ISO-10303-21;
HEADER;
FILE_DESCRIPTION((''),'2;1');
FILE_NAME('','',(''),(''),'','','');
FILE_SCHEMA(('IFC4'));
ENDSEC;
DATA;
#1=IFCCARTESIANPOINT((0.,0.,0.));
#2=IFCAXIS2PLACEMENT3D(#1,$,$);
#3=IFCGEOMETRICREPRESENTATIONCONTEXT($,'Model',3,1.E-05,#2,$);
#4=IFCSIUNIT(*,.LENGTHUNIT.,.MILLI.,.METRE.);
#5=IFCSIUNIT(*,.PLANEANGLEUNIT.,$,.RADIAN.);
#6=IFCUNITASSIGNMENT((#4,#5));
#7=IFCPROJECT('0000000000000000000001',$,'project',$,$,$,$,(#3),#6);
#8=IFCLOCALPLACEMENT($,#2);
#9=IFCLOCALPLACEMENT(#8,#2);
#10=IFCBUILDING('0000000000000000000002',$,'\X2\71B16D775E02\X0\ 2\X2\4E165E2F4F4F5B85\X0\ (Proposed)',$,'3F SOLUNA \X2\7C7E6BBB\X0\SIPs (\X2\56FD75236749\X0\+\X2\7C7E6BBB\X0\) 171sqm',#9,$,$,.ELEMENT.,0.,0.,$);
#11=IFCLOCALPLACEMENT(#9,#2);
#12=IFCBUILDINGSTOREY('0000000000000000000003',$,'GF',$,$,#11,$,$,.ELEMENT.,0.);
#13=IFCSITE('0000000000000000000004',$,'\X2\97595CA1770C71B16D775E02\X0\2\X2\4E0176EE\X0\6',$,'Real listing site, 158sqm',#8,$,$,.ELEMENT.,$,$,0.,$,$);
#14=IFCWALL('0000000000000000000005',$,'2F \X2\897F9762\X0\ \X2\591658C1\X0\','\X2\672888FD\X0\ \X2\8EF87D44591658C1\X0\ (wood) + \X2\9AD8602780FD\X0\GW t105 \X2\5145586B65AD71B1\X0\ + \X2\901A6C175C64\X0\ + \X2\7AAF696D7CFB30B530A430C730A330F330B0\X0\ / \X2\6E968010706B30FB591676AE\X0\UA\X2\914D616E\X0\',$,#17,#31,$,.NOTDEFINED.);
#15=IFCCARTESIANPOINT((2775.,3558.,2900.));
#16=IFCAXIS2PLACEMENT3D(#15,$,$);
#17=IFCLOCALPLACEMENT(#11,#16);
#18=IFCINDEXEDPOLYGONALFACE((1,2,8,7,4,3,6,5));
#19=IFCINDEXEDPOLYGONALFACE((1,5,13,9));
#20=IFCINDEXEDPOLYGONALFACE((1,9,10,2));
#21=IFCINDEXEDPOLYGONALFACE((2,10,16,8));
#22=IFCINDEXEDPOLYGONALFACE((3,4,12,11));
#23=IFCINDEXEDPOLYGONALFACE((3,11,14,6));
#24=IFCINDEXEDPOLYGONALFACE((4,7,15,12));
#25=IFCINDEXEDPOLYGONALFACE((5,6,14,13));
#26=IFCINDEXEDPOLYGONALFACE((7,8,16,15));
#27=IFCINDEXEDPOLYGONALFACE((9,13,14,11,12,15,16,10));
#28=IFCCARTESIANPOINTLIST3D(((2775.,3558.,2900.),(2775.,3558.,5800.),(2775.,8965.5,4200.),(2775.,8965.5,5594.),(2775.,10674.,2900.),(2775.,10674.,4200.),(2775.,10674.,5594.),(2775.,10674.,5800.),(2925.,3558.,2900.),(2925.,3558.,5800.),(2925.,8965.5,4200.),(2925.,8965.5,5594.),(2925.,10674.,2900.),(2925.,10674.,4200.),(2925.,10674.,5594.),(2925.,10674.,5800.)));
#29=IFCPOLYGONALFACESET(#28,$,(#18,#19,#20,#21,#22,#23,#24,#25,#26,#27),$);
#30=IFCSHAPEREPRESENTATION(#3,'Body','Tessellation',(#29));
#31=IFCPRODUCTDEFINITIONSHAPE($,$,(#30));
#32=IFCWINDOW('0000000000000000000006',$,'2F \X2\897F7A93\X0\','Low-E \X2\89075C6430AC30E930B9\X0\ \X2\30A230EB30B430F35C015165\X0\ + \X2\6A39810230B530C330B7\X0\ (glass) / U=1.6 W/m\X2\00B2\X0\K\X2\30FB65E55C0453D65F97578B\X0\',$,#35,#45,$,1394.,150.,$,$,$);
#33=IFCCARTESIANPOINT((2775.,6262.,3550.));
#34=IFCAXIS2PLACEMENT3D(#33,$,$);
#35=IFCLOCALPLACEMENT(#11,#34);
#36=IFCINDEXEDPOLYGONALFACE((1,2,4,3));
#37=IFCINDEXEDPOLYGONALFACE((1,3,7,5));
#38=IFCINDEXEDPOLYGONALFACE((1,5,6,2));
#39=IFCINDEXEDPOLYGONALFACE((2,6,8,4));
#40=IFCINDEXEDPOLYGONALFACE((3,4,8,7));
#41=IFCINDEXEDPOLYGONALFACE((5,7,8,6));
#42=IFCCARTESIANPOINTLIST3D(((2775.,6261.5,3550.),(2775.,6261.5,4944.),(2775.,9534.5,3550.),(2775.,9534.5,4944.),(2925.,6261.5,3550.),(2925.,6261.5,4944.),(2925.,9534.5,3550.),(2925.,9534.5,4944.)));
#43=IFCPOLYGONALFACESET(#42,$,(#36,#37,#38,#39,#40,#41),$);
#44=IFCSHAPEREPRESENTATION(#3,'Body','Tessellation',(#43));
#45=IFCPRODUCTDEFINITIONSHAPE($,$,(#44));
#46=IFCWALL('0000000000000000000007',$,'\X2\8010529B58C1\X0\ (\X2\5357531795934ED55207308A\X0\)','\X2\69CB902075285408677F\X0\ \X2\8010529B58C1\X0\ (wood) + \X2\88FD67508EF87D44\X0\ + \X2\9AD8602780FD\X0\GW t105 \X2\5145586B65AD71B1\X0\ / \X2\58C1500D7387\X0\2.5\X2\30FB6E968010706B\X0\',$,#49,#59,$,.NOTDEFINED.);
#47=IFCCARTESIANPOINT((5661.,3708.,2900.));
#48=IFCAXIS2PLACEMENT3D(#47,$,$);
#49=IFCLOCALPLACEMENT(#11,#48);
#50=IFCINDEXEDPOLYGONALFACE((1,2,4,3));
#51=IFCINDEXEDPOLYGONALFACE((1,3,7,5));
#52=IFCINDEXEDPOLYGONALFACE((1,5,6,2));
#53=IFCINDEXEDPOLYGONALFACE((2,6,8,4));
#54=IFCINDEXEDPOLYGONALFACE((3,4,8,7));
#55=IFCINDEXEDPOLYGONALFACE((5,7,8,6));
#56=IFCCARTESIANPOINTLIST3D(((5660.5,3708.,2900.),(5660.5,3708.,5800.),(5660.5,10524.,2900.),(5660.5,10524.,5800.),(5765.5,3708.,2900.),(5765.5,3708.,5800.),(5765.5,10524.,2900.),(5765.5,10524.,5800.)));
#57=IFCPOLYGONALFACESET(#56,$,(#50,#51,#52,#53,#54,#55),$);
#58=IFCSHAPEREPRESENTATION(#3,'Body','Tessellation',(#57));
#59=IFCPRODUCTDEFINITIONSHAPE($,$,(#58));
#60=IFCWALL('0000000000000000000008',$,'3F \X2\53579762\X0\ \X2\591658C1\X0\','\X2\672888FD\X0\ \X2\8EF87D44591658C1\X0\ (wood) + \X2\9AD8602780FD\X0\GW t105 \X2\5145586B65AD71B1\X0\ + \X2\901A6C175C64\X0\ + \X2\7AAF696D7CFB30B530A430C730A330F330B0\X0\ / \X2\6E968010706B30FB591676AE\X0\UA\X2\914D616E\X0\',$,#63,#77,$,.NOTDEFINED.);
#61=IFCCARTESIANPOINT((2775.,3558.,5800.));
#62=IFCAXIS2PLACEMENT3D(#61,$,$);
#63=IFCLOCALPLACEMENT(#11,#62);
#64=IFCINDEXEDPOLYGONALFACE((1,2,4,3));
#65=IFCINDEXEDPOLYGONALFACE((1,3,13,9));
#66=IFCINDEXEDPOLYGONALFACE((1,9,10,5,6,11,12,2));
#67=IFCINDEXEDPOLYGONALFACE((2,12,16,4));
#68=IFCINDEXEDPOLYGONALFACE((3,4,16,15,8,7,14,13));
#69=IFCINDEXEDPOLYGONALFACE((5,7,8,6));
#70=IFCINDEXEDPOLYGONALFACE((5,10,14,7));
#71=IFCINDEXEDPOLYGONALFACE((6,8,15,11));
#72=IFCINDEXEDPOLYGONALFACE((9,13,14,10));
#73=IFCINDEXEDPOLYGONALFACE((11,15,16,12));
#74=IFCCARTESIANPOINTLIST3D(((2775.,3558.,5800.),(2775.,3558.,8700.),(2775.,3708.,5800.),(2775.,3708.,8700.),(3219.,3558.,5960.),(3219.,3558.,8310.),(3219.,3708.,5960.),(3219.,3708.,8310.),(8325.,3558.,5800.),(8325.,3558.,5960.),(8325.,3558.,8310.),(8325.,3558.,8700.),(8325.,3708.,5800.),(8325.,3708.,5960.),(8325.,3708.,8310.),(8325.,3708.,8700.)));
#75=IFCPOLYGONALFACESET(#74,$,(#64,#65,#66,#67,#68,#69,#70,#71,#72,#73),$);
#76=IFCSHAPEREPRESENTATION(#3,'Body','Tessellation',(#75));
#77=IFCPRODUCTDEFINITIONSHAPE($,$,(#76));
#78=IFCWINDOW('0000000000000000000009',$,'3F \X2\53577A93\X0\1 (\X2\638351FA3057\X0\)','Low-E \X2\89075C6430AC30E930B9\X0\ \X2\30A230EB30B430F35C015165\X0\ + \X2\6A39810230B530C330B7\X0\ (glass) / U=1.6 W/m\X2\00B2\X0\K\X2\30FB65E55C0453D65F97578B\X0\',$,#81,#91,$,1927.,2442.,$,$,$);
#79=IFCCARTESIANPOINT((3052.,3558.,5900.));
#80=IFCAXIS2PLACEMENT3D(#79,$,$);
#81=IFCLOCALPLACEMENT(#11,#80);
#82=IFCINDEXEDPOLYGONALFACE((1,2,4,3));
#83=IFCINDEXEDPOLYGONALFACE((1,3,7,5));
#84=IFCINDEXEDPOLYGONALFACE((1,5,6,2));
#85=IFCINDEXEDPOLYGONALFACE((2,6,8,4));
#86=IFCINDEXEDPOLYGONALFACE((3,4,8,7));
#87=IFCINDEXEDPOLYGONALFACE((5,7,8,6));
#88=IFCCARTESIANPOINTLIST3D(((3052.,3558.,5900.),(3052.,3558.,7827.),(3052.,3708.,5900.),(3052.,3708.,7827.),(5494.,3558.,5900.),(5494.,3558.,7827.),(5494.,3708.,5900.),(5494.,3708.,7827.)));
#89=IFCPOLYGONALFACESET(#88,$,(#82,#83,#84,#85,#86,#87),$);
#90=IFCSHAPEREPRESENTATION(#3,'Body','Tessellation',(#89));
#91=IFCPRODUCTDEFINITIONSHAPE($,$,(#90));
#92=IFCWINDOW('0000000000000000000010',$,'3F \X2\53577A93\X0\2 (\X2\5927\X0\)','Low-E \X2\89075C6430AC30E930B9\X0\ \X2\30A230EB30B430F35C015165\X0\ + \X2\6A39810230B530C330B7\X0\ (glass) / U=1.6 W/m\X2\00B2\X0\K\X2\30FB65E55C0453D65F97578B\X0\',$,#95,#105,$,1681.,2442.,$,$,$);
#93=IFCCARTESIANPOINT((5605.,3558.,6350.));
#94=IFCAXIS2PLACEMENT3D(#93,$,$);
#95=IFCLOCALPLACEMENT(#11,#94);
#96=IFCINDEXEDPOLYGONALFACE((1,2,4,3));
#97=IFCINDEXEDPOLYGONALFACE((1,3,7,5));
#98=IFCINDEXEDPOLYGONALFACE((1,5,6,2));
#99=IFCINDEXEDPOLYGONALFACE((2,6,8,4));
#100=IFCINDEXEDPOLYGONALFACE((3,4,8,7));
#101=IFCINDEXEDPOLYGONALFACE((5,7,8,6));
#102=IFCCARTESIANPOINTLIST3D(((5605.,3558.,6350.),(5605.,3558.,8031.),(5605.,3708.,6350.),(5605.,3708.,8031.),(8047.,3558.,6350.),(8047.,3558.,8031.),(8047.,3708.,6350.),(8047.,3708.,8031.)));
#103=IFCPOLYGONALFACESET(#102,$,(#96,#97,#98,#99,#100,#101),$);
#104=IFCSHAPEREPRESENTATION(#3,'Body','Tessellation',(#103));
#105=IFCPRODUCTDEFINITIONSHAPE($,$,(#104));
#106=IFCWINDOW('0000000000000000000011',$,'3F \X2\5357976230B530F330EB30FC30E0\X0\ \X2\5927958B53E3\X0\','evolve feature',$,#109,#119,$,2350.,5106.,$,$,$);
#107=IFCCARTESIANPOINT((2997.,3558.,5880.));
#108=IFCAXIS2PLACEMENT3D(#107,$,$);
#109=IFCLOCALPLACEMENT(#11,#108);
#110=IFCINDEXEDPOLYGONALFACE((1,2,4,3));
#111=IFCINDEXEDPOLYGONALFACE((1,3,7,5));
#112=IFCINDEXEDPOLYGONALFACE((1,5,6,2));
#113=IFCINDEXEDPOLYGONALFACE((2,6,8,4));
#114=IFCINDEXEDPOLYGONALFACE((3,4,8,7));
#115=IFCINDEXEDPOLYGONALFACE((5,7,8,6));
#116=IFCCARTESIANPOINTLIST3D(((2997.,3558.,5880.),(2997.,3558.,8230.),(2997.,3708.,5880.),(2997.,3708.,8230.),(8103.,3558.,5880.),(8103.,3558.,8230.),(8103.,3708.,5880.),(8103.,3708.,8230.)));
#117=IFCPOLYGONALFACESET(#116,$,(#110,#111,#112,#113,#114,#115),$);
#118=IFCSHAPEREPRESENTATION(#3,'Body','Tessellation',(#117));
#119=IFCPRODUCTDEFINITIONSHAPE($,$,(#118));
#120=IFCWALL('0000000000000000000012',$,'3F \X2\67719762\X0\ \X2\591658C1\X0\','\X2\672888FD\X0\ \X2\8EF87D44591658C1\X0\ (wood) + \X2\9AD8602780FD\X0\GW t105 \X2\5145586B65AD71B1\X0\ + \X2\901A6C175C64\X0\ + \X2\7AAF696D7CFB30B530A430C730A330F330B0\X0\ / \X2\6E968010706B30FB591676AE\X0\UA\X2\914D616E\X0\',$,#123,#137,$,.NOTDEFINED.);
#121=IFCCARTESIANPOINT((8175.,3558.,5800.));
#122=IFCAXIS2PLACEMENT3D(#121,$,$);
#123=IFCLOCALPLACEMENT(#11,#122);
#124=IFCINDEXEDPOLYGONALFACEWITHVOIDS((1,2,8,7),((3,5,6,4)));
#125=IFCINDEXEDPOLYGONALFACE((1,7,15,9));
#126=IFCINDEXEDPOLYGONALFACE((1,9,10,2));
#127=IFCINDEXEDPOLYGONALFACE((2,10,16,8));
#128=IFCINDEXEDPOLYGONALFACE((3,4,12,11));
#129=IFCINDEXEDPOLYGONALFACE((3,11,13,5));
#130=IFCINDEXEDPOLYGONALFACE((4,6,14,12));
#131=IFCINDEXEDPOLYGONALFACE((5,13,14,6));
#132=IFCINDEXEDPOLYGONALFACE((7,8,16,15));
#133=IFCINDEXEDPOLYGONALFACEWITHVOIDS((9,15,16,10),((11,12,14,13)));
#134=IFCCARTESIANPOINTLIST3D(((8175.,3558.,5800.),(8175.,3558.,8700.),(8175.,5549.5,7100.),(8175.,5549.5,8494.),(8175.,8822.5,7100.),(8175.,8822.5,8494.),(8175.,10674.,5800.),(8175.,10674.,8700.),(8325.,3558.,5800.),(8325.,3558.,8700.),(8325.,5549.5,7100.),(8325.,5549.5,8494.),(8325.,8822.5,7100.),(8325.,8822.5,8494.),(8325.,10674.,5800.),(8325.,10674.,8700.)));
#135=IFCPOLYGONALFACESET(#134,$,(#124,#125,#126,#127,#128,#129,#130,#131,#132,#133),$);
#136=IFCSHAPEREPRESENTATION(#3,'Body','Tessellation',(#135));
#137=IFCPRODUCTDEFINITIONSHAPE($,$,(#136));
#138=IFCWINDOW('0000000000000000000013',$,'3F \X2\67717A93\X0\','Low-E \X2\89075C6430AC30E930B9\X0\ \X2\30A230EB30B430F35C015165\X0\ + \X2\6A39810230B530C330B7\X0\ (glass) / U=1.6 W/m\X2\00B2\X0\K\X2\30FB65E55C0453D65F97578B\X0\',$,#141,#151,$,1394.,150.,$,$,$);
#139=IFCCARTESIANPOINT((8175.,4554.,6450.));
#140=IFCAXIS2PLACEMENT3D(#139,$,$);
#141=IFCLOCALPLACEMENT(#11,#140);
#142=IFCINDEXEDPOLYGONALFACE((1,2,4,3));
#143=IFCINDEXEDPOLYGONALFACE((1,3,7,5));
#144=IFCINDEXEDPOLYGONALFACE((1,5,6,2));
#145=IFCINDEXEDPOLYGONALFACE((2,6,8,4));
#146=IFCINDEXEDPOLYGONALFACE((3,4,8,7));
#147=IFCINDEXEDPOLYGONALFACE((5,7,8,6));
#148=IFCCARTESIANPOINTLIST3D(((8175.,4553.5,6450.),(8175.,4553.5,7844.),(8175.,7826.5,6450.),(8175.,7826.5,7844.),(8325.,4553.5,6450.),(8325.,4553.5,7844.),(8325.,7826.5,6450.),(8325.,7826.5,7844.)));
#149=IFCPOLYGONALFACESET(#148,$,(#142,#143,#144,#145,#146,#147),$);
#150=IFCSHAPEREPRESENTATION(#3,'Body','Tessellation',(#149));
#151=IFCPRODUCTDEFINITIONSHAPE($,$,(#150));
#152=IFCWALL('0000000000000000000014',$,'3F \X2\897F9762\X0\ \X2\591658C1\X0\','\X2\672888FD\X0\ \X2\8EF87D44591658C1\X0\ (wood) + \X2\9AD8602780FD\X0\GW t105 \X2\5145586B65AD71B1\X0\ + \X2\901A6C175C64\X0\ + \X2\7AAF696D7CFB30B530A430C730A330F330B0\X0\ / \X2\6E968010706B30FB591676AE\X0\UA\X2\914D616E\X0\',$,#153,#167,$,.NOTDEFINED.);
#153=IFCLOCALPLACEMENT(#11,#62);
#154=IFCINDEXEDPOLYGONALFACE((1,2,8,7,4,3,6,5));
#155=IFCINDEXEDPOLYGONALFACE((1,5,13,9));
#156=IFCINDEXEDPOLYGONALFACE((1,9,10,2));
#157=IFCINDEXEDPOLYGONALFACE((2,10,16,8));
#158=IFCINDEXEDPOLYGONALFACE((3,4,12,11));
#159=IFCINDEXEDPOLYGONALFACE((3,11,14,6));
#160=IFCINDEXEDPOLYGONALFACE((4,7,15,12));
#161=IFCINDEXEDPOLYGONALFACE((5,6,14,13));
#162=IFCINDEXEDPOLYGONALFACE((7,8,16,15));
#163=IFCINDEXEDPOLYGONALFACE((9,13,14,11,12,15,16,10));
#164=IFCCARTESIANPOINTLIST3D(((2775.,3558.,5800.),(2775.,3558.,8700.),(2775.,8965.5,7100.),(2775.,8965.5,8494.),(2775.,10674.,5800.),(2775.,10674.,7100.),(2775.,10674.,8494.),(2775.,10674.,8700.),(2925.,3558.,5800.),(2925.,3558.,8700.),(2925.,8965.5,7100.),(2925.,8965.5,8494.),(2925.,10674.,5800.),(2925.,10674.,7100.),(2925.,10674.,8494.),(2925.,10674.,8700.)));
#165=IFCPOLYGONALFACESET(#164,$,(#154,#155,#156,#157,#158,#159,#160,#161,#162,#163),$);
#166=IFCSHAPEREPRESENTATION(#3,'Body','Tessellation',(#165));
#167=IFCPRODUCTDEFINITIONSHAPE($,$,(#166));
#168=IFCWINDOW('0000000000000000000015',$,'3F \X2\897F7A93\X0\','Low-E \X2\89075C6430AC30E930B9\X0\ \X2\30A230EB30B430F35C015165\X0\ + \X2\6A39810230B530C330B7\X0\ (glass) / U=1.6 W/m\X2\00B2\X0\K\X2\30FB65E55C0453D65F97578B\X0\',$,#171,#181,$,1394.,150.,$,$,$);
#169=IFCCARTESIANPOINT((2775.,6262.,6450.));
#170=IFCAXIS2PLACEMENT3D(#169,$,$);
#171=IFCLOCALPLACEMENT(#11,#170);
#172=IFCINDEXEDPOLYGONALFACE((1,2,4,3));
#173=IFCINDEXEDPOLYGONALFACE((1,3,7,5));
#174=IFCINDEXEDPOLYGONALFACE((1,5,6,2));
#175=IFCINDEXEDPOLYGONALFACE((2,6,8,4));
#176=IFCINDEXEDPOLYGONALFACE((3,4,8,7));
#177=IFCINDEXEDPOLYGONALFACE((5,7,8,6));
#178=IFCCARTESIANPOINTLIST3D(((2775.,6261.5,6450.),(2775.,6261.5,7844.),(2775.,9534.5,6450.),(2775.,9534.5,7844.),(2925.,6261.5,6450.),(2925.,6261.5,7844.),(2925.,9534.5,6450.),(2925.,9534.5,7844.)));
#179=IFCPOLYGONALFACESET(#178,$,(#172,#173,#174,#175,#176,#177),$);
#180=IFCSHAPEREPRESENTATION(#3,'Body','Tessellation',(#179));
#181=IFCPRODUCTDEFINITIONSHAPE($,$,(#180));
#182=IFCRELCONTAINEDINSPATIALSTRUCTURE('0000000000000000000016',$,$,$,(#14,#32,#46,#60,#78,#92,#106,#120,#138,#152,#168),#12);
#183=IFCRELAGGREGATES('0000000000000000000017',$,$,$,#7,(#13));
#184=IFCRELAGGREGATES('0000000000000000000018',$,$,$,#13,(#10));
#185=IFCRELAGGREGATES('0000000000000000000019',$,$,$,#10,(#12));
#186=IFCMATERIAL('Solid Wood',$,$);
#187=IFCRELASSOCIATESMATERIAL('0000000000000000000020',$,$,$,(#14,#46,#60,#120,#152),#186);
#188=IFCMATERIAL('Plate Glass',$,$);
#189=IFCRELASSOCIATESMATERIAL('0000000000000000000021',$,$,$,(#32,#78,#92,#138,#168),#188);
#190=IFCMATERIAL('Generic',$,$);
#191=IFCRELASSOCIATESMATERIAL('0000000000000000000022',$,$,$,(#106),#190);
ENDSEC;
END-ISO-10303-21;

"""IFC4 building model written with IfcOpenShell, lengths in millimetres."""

from ifc_helpers import new_model, si_unit, frame, frame_2d, origin, place, context, project, spatial, rectangle, extrude, material, element, fill, save


model = new_model("IFC4")

# Units and contexts
model_context = context("Model", 3, precision=1e-05, world=origin())
ifc_project = project(units=[si_unit("LENGTHUNIT", "METRE", prefix="MILLI"), si_unit("PLANEANGLEUNIT", "RADIAN")], contexts=[model_context])

# Site, building, storey
site_placement = place(None, origin())
site = spatial("IfcSite", under=ifc_project, at=site_placement, Name="静岡県熱海市2丁目6", ObjectType="Real listing site, 158sqm", CompositionType="ELEMENT", RefElevation=0.0)
building_placement = place(site_placement, origin())
building = spatial("IfcBuilding", under=site, at=building_placement, Name="熱海市 2世帯住宅 (Proposed)", ObjectType="3F SOLUNA 籾殻SIPs (国産杉+籾殻) 171sqm", CompositionType="ELEMENT", ElevationOfRefHeight=0.0, ElevationOfTerrain=0.0)
storey_placement = place(building_placement, origin())
storey = spatial("IfcBuildingStorey", under=building, at=storey_placement, Name="GF", CompositionType="ELEMENT", Elevation=0.0)

# Shared definitions
ifc_material_1 = material(Name="Solid Wood")

# Wall, opening, window
wall_1_placement = place(storey_placement, frame((2775.0, 3558.0, 2900.0)))
wall_1 = element("IfcWall", 1, at=wall_1_placement, inside=storey, material=ifc_material_1, Name="2F 西面 外壁", Description="木製 軸組外壁 (wood) + 高性能GW t105 充填断熱 + 通気層 + 窯業系サイディング / 準耐火・外皮UA配慮", PredefinedType="NOTDEFINED", context=model_context, shape_type="SweptSolid", body=[
    extrude(rectangle(XDim=150.0, YDim=7116.0, at=frame_2d((75.0, 3558.0))), frame((2775.0, 3558.0, 2900.0)), (0.0, 0.0, 1.0), 2900.0),
])
opening_1_placement = place(storey_placement, frame((2775.0, 6262.0, 3550.0)))
opening_1 = element("IfcOpeningElement", 2, at=opening_1_placement, cuts=wall_1, PredefinedType="NOTDEFINED", context=model_context, shape_type="SweptSolid", body=[
    extrude(rectangle(XDim=150.0, YDim=3273.0, at=frame_2d((75.0, 1636.0))), frame((2775.0, 6262.0, 3550.0)), (0.0, 0.0, 1.0), 1394.0),
])
ifc_material_2 = material(Name="Plate Glass")
window_1_placement = place(storey_placement, frame((2775.0, 6262.0, 3550.0)))
window_1 = element("IfcWindow", 3, at=window_1_placement, inside=storey, material=ifc_material_2, Name="2F 西窓", Description="Low-E 複層ガラス アルゴン封入 + 樹脂サッシ (glass) / U=1.6 W/m²K・日射取得型", OverallHeight=1394.0, OverallWidth=150.0, context=model_context, shape_type="SweptSolid", body=[
    extrude(rectangle(XDim=150.0, YDim=3273.0, at=frame_2d((75.0, 1636.0))), frame((2775.0, 6262.0, 3550.0)), (0.0, 0.0, 1.0), 1394.0),
])
fill(opening_1, window_1)

# Wall
wall_2_placement = place(storey_placement, frame((5661.0, 3708.0, 2900.0)))
element("IfcWall", 4, at=wall_2_placement, inside=storey, material=ifc_material_1, Name="耐力壁 (南北間仕切り)", Description="構造用合板 耐力壁 (wood) + 製材軸組 + 高性能GW t105 充填断熱 / 壁倍率2.5・準耐火", PredefinedType="NOTDEFINED", context=model_context, shape_type="SweptSolid", body=[
    extrude(rectangle(XDim=105.0, YDim=6816.0, at=frame_2d((52.0, 3408.0))), frame((5661.0, 3708.0, 2900.0)), (0.0, 0.0, 1.0), 2900.0),
])

# Wall, openings, windows
wall_3_placement = place(storey_placement, frame((2775.0, 3558.0, 5800.0)))
wall_3 = element("IfcWall", 5, at=wall_3_placement, inside=storey, material=ifc_material_1, Name="3F 南面 外壁", Description="木製 軸組外壁 (wood) + 高性能GW t105 充填断熱 + 通気層 + 窯業系サイディング / 準耐火・外皮UA配慮", PredefinedType="NOTDEFINED", context=model_context, shape_type="SweptSolid", body=[
    extrude(rectangle(XDim=5550.0, YDim=150.0, at=frame_2d((2775.0, 75.0))), frame((2775.0, 3558.0, 5800.0)), (0.0, 0.0, 1.0), 2900.0),
])
opening_2_placement = place(storey_placement, frame((3052.0, 3558.0, 5900.0)))
opening_2 = element("IfcOpeningElement", 6, at=opening_2_placement, cuts=wall_3, PredefinedType="NOTDEFINED", context=model_context, shape_type="SweptSolid", body=[
    extrude(rectangle(XDim=2442.0, YDim=150.0, at=frame_2d((1221.0, 75.0))), frame((3052.0, 3558.0, 5900.0)), (0.0, 0.0, 1.0), 1927.0),
])
opening_3_placement = place(storey_placement, frame((5605.0, 3558.0, 6350.0)))
opening_3 = element("IfcOpeningElement", 7, at=opening_3_placement, cuts=wall_3, PredefinedType="NOTDEFINED", context=model_context, shape_type="SweptSolid", body=[
    extrude(rectangle(XDim=2442.0, YDim=150.0, at=frame_2d((1221.0, 75.0))), frame((5605.0, 3558.0, 6350.0)), (0.0, 0.0, 1.0), 1681.0),
])
opening_4_placement = place(storey_placement, frame((2997.0, 3558.0, 5880.0)))
opening_4 = element("IfcOpeningElement", 8, at=opening_4_placement, cuts=wall_3, PredefinedType="NOTDEFINED", context=model_context, shape_type="SweptSolid", body=[
    extrude(rectangle(XDim=5106.0, YDim=150.0, at=frame_2d((2553.0, 75.0))), frame((2997.0, 3558.0, 5880.0)), (0.0, 0.0, 1.0), 2350.0),
])
window_2_placement = place(storey_placement, frame((3052.0, 3558.0, 5900.0)))
window_2 = element("IfcWindow", 9, at=window_2_placement, inside=storey, material=ifc_material_2, Name="3F 南窓1 (掃出し)", Description="Low-E 複層ガラス アルゴン封入 + 樹脂サッシ (glass) / U=1.6 W/m²K・日射取得型", OverallHeight=1927.0, OverallWidth=2442.0, context=model_context, shape_type="SweptSolid", body=[
    extrude(rectangle(XDim=2442.0, YDim=150.0, at=frame_2d((1221.0, 75.0))), frame((3052.0, 3558.0, 5900.0)), (0.0, 0.0, 1.0), 1927.0),
])
fill(opening_2, window_2)
window_3_placement = place(storey_placement, frame((5605.0, 3558.0, 6350.0)))
window_3 = element("IfcWindow", 10, at=window_3_placement, inside=storey, material=ifc_material_2, Name="3F 南窓2 (大)", Description="Low-E 複層ガラス アルゴン封入 + 樹脂サッシ (glass) / U=1.6 W/m²K・日射取得型", OverallHeight=1681.0, OverallWidth=2442.0, context=model_context, shape_type="SweptSolid", body=[
    extrude(rectangle(XDim=2442.0, YDim=150.0, at=frame_2d((1221.0, 75.0))), frame((5605.0, 3558.0, 6350.0)), (0.0, 0.0, 1.0), 1681.0),
])
fill(opening_3, window_3)
ifc_material_3 = material(Name="Generic")
window_4_placement = place(storey_placement, frame((2997.0, 3558.0, 5880.0)))
window_4 = element("IfcWindow", 11, at=window_4_placement, inside=storey, material=ifc_material_3, Name="3F 南面サンルーム 大開口", Description="evolve feature", OverallHeight=2350.0, OverallWidth=5106.0, context=model_context, shape_type="SweptSolid", body=[
    extrude(rectangle(XDim=5106.0, YDim=150.0, at=frame_2d((2553.0, 75.0))), frame((2997.0, 3558.0, 5880.0)), (0.0, 0.0, 1.0), 2350.0),
])
fill(opening_4, window_4)

# Walls, openings, windows
wall_4_placement = place(storey_placement, frame((8175.0, 3558.0, 5800.0)))
wall_4 = element("IfcWall", 12, at=wall_4_placement, inside=storey, material=ifc_material_1, Name="3F 東面 外壁", Description="木製 軸組外壁 (wood) + 高性能GW t105 充填断熱 + 通気層 + 窯業系サイディング / 準耐火・外皮UA配慮", PredefinedType="NOTDEFINED", context=model_context, shape_type="SweptSolid", body=[
    extrude(rectangle(XDim=150.0, YDim=7116.0, at=frame_2d((75.0, 3558.0))), frame((8175.0, 3558.0, 5800.0)), (0.0, 0.0, 1.0), 2900.0),
])
opening_5_placement = place(storey_placement, frame((8175.0, 4554.0, 6450.0)))
opening_5 = element("IfcOpeningElement", 13, at=opening_5_placement, cuts=wall_4, PredefinedType="NOTDEFINED", context=model_context, shape_type="SweptSolid", body=[
    extrude(rectangle(XDim=150.0, YDim=3273.0, at=frame_2d((75.0, 1636.0))), frame((8175.0, 4554.0, 6450.0)), (0.0, 0.0, 1.0), 1394.0),
])
window_5_placement = place(storey_placement, frame((8175.0, 4554.0, 6450.0)))
window_5 = element("IfcWindow", 14, at=window_5_placement, inside=storey, material=ifc_material_2, Name="3F 東窓", Description="Low-E 複層ガラス アルゴン封入 + 樹脂サッシ (glass) / U=1.6 W/m²K・日射取得型", OverallHeight=1394.0, OverallWidth=150.0, context=model_context, shape_type="SweptSolid", body=[
    extrude(rectangle(XDim=150.0, YDim=3273.0, at=frame_2d((75.0, 1636.0))), frame((8175.0, 4554.0, 6450.0)), (0.0, 0.0, 1.0), 1394.0),
])
fill(opening_5, window_5)
wall_5_placement = place(storey_placement, frame((2775.0, 3558.0, 5800.0)))
wall_5 = element("IfcWall", 15, at=wall_5_placement, inside=storey, material=ifc_material_1, Name="3F 西面 外壁", Description="木製 軸組外壁 (wood) + 高性能GW t105 充填断熱 + 通気層 + 窯業系サイディング / 準耐火・外皮UA配慮", PredefinedType="NOTDEFINED", context=model_context, shape_type="SweptSolid", body=[
    extrude(rectangle(XDim=150.0, YDim=7116.0, at=frame_2d((75.0, 3558.0))), frame((2775.0, 3558.0, 5800.0)), (0.0, 0.0, 1.0), 2900.0),
])
opening_6_placement = place(storey_placement, frame((2775.0, 6262.0, 6450.0)))
opening_6 = element("IfcOpeningElement", 16, at=opening_6_placement, cuts=wall_5, PredefinedType="NOTDEFINED", context=model_context, shape_type="SweptSolid", body=[
    extrude(rectangle(XDim=150.0, YDim=3273.0, at=frame_2d((75.0, 1636.0))), frame((2775.0, 6262.0, 6450.0)), (0.0, 0.0, 1.0), 1394.0),
])
window_6_placement = place(storey_placement, frame((2775.0, 6262.0, 6450.0)))
window_6 = element("IfcWindow", 17, at=window_6_placement, inside=storey, material=ifc_material_2, Name="3F 西窓", Description="Low-E 複層ガラス アルゴン封入 + 樹脂サッシ (glass) / U=1.6 W/m²K・日射取得型", OverallHeight=1394.0, OverallWidth=150.0, context=model_context, shape_type="SweptSolid", body=[
    extrude(rectangle(XDim=150.0, YDim=3273.0, at=frame_2d((75.0, 1636.0))), frame((2775.0, 6262.0, 6450.0)), (0.0, 0.0, 1.0), 1394.0),
])
fill(opening_6, window_6)

save(model, "model.ifc")
